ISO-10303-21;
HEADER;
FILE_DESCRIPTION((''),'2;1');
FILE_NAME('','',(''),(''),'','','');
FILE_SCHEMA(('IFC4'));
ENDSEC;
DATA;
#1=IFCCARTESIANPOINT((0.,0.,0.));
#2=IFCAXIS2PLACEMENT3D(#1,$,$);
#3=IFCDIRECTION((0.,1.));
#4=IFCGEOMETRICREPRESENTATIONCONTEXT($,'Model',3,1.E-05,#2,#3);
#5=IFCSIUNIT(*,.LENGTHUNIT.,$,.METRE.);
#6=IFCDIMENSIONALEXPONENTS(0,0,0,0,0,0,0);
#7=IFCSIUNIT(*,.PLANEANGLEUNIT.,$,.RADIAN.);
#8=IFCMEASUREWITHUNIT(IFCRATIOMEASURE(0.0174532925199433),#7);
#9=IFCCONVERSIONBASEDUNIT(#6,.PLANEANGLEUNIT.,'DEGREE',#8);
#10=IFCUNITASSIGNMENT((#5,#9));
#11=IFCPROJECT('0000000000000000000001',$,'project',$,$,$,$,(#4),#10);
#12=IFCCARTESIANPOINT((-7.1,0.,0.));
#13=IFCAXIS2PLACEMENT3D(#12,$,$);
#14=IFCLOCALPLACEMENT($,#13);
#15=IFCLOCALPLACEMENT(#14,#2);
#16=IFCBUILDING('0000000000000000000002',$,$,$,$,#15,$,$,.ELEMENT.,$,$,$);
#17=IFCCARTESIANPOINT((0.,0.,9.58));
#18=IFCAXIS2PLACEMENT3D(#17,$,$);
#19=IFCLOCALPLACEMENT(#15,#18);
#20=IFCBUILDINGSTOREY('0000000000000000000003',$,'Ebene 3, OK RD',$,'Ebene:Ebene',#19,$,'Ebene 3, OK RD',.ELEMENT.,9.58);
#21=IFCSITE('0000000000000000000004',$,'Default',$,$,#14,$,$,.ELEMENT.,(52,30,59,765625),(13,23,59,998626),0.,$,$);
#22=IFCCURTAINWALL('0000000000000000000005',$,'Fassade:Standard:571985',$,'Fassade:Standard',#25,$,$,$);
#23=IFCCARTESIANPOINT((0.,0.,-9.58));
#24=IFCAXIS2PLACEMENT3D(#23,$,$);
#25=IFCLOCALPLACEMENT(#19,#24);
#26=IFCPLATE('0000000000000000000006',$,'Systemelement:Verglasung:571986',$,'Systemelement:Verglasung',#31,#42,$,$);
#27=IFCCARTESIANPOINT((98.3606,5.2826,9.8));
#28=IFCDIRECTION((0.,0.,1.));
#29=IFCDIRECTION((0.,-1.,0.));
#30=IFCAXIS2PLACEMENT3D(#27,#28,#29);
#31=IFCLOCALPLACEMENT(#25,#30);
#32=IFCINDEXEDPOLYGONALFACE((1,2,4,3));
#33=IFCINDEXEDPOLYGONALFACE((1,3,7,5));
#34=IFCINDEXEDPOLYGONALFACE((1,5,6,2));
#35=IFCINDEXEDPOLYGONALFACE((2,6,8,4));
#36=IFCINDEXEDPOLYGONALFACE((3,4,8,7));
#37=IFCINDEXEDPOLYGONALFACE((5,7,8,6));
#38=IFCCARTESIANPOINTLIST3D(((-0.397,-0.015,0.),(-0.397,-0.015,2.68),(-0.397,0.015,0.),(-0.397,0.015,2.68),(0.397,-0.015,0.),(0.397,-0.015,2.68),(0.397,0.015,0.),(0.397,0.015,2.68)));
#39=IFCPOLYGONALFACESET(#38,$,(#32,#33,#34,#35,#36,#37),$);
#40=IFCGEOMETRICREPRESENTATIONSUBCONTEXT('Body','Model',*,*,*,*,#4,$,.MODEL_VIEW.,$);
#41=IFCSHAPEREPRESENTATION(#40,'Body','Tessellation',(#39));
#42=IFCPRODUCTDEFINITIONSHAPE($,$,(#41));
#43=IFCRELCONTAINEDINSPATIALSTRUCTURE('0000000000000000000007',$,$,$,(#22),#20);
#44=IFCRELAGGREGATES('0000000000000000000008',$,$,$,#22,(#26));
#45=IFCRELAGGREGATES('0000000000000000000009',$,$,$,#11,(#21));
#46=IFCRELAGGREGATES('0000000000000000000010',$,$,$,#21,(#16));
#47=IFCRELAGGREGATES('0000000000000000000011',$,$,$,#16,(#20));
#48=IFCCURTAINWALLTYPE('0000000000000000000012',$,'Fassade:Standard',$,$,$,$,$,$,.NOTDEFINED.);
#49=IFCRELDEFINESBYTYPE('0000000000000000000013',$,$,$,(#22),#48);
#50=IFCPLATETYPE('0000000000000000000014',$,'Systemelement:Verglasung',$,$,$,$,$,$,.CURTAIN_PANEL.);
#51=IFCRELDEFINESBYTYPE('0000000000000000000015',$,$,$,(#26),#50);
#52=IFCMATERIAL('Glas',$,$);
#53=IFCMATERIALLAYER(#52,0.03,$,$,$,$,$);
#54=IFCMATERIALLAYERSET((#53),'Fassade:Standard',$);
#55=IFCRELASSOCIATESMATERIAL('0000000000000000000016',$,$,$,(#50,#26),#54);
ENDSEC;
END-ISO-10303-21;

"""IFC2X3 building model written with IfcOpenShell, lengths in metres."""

from ifc_helpers import new_model, entity, si_unit, converted_unit, direction, frame, origin, origin_2d_with_axis, place, context, subcontext, project, spatial, rectangle, extrude, source, transform, mapped, material, layer, layer_set, layer_usage, type_object, type_shapes, element, aggregate, save


model = new_model("IFC2X3")

# Units and contexts
model_context = context("Model", 3, precision=1e-05, world=origin(), true_north=direction((0.0, 1.0)))
body_context = subcontext(model_context, "Body", "Model", "MODEL_VIEW")
ifc_project = project(units=[si_unit("LENGTHUNIT", "METRE"), converted_unit("PLANEANGLEUNIT", "DEGREE", entity("IfcRatioMeasure", 0.0174532925199433), si_unit("PLANEANGLEUNIT", "RADIAN"), dimensions=[0, 0, 0, 0, 0, 0, 0])], contexts=[model_context])

# Site, building, storey
site_placement = place(None, frame((-7.1, 0.0, 0.0)))
site = spatial("IfcSite", under=ifc_project, at=site_placement, Name="Default", CompositionType="ELEMENT", RefLatitude=(52, 30, 59, 765625), RefLongitude=(13, 23, 59, 998626), RefElevation=0.0)
building_placement = place(site_placement, origin())
building = spatial("IfcBuilding", under=site, at=building_placement, CompositionType="ELEMENT")
storey_placement = place(building_placement, frame((0.0, 0.0, 9.58)))
storey = spatial("IfcBuildingStorey", under=building, at=storey_placement, Name="Ebene 3, OK RD", ObjectType="Ebene:Ebene", LongName="Ebene 3, OK RD", CompositionType="ELEMENT", Elevation=9.58)

# Curtain wall, plate
curtain_wall_type = type_object("IfcCurtainWallType", Name="Fassade:Standard", PredefinedType="NOTDEFINED")
curtain_wall_placement = place(storey_placement, frame((0.0, 0.0, -9.58)))
curtain_wall = element("IfcCurtainWall", 1, at=curtain_wall_placement, inside=storey, type_object=curtain_wall_type, Name="Fassade:Standard:571985", ObjectType="Fassade:Standard")
ifc_material_1 = material(Name="Glas")
ifc_layer_1 = layer(ifc_material_1, 0.03)
ifc_layer_set_1 = layer_set([ifc_layer_1], Name="Fassade:Standard")
ifc_layer_usage_1 = layer_usage(ifc_layer_set_1, "AXIS3", "POSITIVE", 0.0)
plate_type = type_object("IfcPlateType", Name="Systemelement:Verglasung", PredefinedType="CURTAIN_PANEL", material=ifc_layer_set_1)
shared_shape = source(origin(), body_context, "Body", "SweptSolid", [
    extrude(rectangle(XDim=0.03, YDim=0.794, at=origin_2d_with_axis()), frame((0.0, 0.0, 0.0), z_axis=(0.0, 0.0, 1.0), x_axis=(0.0, 1.0, 0.0)), (0.0, 0.0, 1.0), 2.68),
])
type_shapes(plate_type, [shared_shape])
plate_placement = place(curtain_wall_placement, frame((98.3606, 5.2826, 9.8), z_axis=(0.0, 0.0, 1.0), x_axis=(0.0, -1.0, 0.0)))
plate = element("IfcPlate", 2, at=plate_placement, type_object=plate_type, material=ifc_layer_usage_1, Name="Systemelement:Verglasung:571986", ObjectType="Systemelement:Verglasung", context=body_context, shape_type="MappedRepresentation", body=[
    mapped(shared_shape, transform((0.0, 0.0, 0.0), scale=1.0)),
])
aggregate(curtain_wall, [plate])

save(model, "model.ifc")
